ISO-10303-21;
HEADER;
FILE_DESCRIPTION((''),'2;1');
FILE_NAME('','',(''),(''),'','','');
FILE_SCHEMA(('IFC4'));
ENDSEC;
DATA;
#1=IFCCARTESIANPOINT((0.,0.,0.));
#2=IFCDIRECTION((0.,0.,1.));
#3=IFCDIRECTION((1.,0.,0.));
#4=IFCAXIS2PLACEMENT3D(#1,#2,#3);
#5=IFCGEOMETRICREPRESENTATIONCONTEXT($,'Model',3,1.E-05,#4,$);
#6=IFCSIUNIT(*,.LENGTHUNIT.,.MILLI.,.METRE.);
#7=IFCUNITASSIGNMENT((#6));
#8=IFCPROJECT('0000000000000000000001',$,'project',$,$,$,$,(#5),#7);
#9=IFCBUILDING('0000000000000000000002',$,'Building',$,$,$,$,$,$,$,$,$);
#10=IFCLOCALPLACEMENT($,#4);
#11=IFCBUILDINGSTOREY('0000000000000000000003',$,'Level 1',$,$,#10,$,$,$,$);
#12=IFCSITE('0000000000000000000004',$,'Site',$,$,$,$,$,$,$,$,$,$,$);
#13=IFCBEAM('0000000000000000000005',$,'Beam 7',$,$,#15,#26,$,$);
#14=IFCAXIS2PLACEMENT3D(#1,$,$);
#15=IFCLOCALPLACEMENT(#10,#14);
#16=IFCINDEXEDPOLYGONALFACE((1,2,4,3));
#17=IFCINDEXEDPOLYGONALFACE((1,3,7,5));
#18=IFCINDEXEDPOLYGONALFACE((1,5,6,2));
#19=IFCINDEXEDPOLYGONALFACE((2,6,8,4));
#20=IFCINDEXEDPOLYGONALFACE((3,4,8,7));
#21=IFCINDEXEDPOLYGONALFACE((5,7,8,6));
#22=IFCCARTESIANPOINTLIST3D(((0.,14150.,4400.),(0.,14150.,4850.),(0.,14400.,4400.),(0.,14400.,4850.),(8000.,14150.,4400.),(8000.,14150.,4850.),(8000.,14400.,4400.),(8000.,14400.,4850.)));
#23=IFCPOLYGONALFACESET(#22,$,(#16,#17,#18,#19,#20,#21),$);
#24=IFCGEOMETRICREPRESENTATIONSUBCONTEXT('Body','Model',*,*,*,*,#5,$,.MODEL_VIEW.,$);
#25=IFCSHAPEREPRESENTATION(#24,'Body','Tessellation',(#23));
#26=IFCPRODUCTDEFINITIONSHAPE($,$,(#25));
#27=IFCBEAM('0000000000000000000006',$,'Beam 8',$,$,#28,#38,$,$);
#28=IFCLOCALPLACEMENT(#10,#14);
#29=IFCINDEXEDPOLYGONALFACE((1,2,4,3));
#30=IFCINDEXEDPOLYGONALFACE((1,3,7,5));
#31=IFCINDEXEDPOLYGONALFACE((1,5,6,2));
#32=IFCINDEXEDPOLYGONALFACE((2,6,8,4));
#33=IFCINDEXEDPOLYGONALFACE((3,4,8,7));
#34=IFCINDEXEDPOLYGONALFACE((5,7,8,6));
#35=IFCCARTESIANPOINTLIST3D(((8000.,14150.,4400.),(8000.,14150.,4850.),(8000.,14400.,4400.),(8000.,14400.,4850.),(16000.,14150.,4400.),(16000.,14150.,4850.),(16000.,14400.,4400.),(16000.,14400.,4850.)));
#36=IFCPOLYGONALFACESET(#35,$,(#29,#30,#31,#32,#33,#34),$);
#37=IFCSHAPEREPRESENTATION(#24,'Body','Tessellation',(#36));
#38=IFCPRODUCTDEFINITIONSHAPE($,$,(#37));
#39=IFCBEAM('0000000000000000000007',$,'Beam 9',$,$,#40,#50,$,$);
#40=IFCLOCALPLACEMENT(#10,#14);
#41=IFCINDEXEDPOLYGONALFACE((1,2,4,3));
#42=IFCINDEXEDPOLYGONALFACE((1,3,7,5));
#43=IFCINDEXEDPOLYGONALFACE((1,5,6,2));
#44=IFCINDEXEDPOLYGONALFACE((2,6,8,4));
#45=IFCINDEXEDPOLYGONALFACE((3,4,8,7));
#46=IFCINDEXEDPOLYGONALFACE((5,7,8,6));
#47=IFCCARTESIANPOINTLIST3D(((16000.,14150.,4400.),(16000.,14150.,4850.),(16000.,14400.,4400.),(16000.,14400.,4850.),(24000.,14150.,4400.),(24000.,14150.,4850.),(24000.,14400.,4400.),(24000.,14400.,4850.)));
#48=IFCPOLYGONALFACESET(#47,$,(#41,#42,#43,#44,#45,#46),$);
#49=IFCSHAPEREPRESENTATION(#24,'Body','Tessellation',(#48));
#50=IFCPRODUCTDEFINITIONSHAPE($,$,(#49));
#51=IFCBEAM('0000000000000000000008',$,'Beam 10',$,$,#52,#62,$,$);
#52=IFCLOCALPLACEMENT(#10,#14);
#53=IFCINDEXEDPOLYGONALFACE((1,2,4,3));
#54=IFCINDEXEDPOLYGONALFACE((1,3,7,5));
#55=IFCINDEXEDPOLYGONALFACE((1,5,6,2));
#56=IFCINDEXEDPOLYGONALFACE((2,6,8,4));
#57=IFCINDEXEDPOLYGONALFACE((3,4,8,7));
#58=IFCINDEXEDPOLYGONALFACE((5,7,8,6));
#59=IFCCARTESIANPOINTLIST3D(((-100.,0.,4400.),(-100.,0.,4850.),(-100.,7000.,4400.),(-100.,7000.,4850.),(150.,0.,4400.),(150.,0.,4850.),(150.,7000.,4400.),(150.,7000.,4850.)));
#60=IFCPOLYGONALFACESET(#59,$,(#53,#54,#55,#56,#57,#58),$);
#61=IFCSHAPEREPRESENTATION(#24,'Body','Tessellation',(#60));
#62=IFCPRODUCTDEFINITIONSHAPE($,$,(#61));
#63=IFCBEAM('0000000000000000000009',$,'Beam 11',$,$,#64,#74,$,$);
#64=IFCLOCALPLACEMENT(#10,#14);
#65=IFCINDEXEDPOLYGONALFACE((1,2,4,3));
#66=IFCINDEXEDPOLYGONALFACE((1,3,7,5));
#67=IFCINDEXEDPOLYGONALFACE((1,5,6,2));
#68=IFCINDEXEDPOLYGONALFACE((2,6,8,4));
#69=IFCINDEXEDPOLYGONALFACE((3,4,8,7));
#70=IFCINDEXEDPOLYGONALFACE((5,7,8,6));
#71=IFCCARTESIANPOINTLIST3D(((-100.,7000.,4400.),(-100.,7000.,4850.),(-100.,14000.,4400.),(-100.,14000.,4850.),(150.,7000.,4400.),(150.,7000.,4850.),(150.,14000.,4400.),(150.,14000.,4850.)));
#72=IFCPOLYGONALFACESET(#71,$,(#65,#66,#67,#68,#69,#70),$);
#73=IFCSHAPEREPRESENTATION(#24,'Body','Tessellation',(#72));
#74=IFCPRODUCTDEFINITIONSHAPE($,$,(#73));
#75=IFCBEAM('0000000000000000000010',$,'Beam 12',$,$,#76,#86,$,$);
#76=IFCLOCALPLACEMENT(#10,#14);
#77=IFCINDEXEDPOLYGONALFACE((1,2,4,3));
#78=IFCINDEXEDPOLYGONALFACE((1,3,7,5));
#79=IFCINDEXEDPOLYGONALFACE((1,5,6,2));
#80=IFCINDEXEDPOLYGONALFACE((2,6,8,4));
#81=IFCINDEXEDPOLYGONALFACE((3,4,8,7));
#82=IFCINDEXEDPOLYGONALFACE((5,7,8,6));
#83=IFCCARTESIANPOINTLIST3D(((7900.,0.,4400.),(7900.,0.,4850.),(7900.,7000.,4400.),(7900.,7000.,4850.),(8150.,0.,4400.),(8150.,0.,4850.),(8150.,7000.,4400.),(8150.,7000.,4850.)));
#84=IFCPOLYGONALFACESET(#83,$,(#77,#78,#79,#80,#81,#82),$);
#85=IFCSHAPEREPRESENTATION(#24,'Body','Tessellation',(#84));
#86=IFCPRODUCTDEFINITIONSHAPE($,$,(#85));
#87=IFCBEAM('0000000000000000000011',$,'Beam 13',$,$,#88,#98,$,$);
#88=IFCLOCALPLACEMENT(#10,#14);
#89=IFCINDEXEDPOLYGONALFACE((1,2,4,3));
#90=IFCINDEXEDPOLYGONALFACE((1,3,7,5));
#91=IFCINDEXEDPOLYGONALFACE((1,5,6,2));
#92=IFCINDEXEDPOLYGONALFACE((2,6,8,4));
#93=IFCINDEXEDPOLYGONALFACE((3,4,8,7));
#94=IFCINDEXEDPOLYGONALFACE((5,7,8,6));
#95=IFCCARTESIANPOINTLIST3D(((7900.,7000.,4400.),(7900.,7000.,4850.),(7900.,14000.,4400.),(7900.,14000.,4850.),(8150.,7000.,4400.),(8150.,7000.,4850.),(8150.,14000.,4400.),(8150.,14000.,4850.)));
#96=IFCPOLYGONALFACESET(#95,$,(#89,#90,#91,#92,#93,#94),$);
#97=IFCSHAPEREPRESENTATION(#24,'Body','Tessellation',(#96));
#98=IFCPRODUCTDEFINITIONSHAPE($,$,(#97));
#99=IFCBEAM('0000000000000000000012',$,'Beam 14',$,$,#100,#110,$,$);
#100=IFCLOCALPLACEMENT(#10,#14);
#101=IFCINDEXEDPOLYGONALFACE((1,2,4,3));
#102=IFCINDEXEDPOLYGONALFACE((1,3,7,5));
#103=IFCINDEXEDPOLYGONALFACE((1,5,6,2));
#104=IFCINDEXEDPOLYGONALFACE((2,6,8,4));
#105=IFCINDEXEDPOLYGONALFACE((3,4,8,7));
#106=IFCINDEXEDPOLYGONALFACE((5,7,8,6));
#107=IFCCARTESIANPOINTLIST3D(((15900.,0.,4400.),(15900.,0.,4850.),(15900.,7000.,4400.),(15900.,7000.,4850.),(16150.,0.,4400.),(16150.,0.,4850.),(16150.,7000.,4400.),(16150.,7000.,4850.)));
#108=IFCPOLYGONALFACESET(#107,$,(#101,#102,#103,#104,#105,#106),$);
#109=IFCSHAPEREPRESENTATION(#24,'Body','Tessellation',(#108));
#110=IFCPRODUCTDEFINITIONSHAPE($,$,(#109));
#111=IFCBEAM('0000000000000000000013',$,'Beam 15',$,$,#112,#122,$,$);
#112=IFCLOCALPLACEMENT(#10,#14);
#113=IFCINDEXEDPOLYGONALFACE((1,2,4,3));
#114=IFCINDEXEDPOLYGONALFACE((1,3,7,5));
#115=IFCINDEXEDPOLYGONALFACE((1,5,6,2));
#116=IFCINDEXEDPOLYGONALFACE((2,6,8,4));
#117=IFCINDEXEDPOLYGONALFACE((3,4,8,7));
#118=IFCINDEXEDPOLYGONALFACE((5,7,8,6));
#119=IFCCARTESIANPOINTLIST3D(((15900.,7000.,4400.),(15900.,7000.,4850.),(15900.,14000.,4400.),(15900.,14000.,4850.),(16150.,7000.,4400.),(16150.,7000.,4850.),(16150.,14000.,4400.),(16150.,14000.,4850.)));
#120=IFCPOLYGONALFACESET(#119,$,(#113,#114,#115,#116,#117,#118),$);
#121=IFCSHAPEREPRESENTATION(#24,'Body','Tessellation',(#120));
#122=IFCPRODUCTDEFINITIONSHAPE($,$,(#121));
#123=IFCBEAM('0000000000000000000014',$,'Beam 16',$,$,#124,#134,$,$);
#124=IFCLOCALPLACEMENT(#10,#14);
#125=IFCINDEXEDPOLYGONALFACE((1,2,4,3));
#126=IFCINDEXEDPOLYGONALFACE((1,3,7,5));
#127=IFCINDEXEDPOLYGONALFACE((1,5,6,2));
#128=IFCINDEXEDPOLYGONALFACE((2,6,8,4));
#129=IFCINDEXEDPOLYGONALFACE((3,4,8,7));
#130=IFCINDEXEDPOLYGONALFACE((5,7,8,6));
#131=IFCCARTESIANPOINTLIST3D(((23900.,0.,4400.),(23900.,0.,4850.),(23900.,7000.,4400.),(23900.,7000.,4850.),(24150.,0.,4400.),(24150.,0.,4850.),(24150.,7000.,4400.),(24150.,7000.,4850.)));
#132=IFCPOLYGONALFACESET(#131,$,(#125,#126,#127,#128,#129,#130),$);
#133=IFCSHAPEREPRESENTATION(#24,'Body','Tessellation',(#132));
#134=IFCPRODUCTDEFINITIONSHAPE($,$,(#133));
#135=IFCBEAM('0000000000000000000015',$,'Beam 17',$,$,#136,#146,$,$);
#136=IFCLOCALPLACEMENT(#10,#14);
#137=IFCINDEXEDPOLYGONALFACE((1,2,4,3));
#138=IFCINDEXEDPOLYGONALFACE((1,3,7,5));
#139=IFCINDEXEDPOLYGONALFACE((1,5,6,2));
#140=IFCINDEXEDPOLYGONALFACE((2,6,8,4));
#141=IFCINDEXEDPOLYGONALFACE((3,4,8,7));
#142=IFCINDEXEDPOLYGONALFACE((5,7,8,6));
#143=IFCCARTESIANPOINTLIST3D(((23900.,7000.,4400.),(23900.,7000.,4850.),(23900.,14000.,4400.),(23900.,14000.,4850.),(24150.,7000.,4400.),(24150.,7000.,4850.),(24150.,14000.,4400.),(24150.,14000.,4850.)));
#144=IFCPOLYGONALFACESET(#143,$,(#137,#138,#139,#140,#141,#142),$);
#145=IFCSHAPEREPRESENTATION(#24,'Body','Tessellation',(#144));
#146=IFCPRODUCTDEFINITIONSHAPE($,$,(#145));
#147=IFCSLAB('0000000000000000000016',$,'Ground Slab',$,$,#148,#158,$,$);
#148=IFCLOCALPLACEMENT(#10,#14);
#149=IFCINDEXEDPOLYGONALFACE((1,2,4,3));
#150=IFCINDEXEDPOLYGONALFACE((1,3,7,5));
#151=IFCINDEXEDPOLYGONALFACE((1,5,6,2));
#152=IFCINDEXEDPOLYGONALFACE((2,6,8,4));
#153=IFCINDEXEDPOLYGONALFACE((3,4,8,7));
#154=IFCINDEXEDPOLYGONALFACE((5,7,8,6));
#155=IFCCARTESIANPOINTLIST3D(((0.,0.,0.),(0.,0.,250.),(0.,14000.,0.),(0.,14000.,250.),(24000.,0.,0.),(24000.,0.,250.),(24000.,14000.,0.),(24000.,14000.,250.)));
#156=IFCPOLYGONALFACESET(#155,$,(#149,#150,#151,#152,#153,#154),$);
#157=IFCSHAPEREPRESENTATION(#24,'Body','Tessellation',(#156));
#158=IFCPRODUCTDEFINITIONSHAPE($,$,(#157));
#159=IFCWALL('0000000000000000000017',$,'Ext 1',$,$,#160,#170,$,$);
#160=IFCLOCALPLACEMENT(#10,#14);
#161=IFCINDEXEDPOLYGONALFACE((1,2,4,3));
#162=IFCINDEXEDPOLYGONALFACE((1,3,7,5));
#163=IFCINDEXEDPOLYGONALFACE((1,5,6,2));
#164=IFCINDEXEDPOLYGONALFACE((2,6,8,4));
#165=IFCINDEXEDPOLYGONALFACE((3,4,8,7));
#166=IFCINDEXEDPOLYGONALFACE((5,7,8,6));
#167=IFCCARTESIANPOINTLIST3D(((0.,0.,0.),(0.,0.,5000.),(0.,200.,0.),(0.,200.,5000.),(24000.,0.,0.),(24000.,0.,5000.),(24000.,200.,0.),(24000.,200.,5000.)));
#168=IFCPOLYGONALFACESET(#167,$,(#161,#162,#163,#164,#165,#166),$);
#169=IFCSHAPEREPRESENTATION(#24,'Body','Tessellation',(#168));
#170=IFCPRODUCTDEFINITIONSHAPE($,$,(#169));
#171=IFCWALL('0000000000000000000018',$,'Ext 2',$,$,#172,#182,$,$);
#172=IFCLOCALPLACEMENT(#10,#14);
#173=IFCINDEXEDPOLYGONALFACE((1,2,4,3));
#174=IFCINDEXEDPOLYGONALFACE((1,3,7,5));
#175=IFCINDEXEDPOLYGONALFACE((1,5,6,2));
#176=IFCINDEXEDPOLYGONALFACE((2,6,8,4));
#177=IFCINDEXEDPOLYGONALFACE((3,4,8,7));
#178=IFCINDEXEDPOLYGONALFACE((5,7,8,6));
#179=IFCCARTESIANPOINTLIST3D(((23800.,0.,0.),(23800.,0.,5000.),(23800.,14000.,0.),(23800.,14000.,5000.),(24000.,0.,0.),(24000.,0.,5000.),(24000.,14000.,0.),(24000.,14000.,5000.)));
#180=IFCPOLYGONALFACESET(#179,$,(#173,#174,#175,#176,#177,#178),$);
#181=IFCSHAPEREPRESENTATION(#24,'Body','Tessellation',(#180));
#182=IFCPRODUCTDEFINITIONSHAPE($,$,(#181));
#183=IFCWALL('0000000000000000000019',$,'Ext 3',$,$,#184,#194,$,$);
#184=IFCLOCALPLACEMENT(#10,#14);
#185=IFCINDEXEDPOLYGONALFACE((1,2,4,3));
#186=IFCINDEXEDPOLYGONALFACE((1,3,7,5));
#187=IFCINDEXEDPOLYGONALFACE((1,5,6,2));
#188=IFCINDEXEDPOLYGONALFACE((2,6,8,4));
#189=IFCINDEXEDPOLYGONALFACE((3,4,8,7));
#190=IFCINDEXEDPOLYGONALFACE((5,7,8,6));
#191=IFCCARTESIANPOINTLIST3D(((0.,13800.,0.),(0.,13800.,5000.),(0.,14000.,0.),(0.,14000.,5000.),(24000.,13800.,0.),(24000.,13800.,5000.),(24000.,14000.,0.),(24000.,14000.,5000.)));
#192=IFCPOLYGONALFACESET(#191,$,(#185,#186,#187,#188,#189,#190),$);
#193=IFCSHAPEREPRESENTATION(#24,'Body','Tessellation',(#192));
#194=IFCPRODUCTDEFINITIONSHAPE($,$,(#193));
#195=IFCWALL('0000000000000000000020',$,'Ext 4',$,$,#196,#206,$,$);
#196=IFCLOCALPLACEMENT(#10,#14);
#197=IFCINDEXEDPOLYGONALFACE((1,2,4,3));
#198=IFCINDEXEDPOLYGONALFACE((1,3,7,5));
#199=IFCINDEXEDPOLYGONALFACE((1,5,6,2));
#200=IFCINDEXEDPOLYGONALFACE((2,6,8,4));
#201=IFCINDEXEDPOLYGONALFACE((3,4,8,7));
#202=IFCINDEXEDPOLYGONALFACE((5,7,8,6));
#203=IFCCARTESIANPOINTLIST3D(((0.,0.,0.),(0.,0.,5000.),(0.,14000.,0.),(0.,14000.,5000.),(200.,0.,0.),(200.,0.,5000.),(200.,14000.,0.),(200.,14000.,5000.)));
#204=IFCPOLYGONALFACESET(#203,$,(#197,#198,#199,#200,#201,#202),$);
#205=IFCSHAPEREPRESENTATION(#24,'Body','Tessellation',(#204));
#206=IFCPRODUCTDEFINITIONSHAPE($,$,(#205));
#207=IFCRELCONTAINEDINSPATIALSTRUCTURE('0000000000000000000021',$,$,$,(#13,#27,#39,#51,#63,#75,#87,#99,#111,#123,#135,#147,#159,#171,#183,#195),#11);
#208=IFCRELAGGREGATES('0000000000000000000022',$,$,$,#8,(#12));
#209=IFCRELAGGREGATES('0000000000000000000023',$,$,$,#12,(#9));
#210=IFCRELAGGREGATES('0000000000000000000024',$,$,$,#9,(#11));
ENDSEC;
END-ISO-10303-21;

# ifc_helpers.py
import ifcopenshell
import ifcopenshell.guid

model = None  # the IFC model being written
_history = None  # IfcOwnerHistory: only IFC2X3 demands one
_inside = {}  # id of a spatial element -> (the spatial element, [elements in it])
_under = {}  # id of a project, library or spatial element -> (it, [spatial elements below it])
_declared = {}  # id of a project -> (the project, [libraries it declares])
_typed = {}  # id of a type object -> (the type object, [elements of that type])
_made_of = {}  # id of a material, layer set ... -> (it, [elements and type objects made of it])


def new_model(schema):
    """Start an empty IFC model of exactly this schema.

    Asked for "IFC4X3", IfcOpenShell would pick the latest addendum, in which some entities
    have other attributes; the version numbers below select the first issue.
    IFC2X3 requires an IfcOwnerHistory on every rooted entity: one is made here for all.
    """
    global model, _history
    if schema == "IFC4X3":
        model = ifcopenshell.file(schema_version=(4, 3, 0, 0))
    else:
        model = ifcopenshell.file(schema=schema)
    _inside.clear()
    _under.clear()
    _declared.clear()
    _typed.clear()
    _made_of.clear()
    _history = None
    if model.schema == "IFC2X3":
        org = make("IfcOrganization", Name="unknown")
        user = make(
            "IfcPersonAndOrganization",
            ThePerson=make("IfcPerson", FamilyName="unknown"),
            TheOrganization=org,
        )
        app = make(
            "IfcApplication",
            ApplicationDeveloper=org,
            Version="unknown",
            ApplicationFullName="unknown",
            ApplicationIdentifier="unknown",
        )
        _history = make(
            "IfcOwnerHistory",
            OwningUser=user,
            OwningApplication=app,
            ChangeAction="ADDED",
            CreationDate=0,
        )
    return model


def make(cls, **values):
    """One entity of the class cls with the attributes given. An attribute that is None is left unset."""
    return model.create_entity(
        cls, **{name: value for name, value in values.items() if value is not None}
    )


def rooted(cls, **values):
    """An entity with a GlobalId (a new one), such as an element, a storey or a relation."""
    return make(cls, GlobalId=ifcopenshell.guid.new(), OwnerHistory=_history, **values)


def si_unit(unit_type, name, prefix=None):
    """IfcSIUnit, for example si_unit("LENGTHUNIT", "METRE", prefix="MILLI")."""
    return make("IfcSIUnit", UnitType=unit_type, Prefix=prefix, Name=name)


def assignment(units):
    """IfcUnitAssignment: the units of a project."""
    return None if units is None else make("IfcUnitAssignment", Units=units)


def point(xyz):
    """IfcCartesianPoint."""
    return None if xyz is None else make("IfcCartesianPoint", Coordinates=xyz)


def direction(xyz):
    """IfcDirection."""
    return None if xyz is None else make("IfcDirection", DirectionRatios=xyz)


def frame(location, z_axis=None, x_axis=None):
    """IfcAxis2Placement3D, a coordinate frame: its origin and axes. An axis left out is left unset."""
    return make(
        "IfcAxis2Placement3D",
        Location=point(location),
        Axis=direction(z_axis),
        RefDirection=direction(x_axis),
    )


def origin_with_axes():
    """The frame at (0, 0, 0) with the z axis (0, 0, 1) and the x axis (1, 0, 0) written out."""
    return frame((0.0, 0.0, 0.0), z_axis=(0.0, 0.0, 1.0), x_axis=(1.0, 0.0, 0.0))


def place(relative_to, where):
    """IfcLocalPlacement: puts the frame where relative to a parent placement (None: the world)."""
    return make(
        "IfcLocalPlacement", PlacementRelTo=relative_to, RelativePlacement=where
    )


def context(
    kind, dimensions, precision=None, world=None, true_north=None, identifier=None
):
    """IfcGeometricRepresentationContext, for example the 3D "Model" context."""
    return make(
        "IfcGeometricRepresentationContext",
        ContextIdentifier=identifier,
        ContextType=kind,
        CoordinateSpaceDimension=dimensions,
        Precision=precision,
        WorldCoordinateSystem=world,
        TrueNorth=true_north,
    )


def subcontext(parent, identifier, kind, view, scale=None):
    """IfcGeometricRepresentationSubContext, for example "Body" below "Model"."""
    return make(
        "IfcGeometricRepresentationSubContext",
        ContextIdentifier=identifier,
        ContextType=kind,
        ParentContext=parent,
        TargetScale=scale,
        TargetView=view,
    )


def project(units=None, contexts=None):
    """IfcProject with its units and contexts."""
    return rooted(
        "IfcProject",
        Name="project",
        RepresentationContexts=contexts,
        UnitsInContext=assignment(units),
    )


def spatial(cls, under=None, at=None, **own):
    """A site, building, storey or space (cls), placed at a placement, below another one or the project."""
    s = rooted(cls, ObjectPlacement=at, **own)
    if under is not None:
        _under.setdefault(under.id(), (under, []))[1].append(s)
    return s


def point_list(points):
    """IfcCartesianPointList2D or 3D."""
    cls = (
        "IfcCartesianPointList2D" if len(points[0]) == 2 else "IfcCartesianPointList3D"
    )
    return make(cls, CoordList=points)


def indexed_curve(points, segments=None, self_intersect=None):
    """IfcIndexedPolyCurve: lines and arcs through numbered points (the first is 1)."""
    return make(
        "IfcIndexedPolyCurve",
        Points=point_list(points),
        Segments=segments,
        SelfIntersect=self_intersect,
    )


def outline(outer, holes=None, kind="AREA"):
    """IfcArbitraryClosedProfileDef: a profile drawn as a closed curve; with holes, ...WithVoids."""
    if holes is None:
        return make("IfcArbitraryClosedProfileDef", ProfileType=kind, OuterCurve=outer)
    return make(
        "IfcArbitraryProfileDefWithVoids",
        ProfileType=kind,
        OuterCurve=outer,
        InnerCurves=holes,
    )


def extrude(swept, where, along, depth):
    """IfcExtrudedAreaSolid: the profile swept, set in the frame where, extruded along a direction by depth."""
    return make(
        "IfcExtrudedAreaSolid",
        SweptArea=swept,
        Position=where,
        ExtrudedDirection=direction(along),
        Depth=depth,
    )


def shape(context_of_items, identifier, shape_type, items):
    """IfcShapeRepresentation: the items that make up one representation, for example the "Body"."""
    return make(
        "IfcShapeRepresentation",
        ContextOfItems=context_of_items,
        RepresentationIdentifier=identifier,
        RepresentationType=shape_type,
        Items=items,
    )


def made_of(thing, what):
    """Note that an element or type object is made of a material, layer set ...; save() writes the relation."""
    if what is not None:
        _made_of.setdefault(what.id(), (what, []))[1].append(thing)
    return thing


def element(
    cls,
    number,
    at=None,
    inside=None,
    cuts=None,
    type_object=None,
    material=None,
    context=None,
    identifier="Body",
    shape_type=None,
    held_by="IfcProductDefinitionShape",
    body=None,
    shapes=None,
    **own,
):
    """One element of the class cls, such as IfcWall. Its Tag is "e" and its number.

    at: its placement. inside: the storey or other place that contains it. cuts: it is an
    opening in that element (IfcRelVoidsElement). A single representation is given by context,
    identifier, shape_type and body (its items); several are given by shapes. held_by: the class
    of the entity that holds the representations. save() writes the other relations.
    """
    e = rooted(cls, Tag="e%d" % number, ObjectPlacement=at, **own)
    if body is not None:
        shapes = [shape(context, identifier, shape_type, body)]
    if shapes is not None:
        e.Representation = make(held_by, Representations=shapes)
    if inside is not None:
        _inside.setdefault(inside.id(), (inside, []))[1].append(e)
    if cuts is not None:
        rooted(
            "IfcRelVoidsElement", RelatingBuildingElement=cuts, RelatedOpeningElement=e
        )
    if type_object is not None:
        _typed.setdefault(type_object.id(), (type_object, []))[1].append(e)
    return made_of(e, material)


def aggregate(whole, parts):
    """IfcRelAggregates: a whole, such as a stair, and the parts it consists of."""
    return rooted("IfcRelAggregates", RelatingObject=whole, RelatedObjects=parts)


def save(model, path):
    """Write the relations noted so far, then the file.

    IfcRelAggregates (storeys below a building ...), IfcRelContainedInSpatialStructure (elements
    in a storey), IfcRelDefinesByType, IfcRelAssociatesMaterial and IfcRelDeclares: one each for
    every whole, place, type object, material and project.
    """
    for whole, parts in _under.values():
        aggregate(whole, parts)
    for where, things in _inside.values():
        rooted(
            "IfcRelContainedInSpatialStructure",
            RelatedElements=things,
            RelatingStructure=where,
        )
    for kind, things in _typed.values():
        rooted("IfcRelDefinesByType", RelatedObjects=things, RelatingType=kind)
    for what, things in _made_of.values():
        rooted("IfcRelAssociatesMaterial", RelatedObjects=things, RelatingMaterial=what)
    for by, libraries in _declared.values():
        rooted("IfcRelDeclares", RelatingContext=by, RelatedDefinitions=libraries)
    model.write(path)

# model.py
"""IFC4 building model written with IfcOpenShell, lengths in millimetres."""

from ifc_helpers import new_model, si_unit, frame, origin_with_axes, place, context, subcontext, project, spatial, indexed_curve, outline, extrude, element, save


model = new_model("IFC4")

# Units and contexts
model_context = context("Model", 3, precision=1e-05, world=origin_with_axes())
body_context = subcontext(model_context, "Body", "Model", "MODEL_VIEW")
ifc_project = project(units=[si_unit("LENGTHUNIT", "METRE", prefix="MILLI")], contexts=[model_context])

# Site, building, storey
site = spatial("IfcSite", under=ifc_project, Name="Site")
building = spatial("IfcBuilding", under=site, Name="Building")
storey_placement = place(None, origin_with_axes())
storey = spatial("IfcBuildingStorey", under=building, at=storey_placement, Name="Level 1")

# Beams
for number, where, z_axis, x_axis, name in (
    (1, (0.0, 14150.0, 4400.0), (0.0, 0.0, 1.0), (1.0, 0.0, 0.0), "Beam 7"),
    (2, (8000.0, 14150.0, 4400.0), (0.0, 0.0, 1.0), (1.0, 0.0, 0.0), "Beam 8"),
    (3, (16000.0, 14150.0, 4400.0), (0.0, 0.0, 1.0), (1.0, 0.0, 0.0), "Beam 9"),
):
    element("IfcBeam", number, at=place(storey_placement, frame(where, z_axis=z_axis, x_axis=x_axis)), inside=storey, Name=name, context=body_context, shape_type="SweptSolid", body=[
        extrude(outline(indexed_curve([(0.0, 0.0), (0.0, 250.0), (8000.0, 250.0), (8000.0, 0.0), (0.0, 0.0)], self_intersect=False)), origin_with_axes(), (0.0, 0.0, 1.0), 450.0),
    ])
for number, where, z_axis, x_axis, name in (
    (4, (150.0, 0.0, 4400.0), (0.0, 0.0, 1.0), (0.0, 1.0, 0.0), "Beam 10"),
    (5, (150.0, 7000.0, 4400.0), (0.0, 0.0, 1.0), (0.0, 1.0, 0.0), "Beam 11"),
    (6, (8150.0, 0.0, 4400.0), (0.0, 0.0, 1.0), (0.0, 1.0, 0.0), "Beam 12"),
    (7, (8150.0, 7000.0, 4400.0), (0.0, 0.0, 1.0), (0.0, 1.0, 0.0), "Beam 13"),
    (8, (16150.0, 0.0, 4400.0), (0.0, 0.0, 1.0), (0.0, 1.0, 0.0), "Beam 14"),
    (9, (16150.0, 7000.0, 4400.0), (0.0, 0.0, 1.0), (0.0, 1.0, 0.0), "Beam 15"),
    (10, (24150.0, 0.0, 4400.0), (0.0, 0.0, 1.0), (0.0, 1.0, 0.0), "Beam 16"),
    (11, (24150.0, 7000.0, 4400.0), (0.0, 0.0, 1.0), (0.0, 1.0, 0.0), "Beam 17"),
):
    element("IfcBeam", number, at=place(storey_placement, frame(where, z_axis=z_axis, x_axis=x_axis)), inside=storey, Name=name, context=body_context, shape_type="SweptSolid", body=[
        extrude(outline(indexed_curve([(0.0, 0.0), (0.0, 250.0), (7000.0, 250.0), (7000.0, 0.0), (0.0, 0.0)], self_intersect=False)), origin_with_axes(), (0.0, 0.0, 1.0), 450.0),
    ])

# Slab
slab_placement = place(storey_placement, origin_with_axes())
element("IfcSlab", 12, at=slab_placement, inside=storey, Name="Ground Slab", context=body_context, shape_type="SweptSolid", body=[
    extrude(outline(indexed_curve([(0.0, 0.0), (24000.0, 0.0), (24000.0, 14000.0), (0.0, 14000.0), (0.0, 0.0)])), None, (0.0, 0.0, 1.0), 250.0),
])

# Walls
wall_1_placement = place(storey_placement, origin_with_axes())
element("IfcWall", 13, at=wall_1_placement, inside=storey, Name="Ext 1", context=body_context, shape_type="SweptSolid", body=[
    extrude(outline(indexed_curve([(0.0, 0.0), (0.0, 200.0), (24000.0, 200.0), (24000.0, 0.0), (0.0, 0.0)], self_intersect=False)), origin_with_axes(), (0.0, 0.0, 1.0), 5000.0),
])
wall_2_placement = place(storey_placement, frame((24000.0, 0.0, 0.0), z_axis=(0.0, 0.0, 1.0), x_axis=(0.0, 1.0, 0.0)))
element("IfcWall", 14, at=wall_2_placement, inside=storey, Name="Ext 2", context=body_context, shape_type="SweptSolid", body=[
    extrude(outline(indexed_curve([(0.0, 0.0), (0.0, 200.0), (14000.0, 200.0), (14000.0, 0.0), (0.0, 0.0)], self_intersect=False)), origin_with_axes(), (0.0, 0.0, 1.0), 5000.0),
])
wall_3_placement = place(storey_placement, frame((24000.0, 14000.0, 0.0), z_axis=(0.0, 0.0, 1.0), x_axis=(-1.0, 0.0, 0.0)))
element("IfcWall", 15, at=wall_3_placement, inside=storey, Name="Ext 3", context=body_context, shape_type="SweptSolid", body=[
    extrude(outline(indexed_curve([(0.0, 0.0), (0.0, 200.0), (24000.0, 200.0), (24000.0, 0.0), (0.0, 0.0)], self_intersect=False)), origin_with_axes(), (0.0, 0.0, 1.0), 5000.0),
])
wall_4_placement = place(storey_placement, frame((0.0, 14000.0, 0.0), z_axis=(0.0, 0.0, 1.0), x_axis=(0.0, -1.0, 0.0)))
element("IfcWall", 16, at=wall_4_placement, inside=storey, Name="Ext 4", context=body_context, shape_type="SweptSolid", body=[
    extrude(outline(indexed_curve([(0.0, 0.0), (0.0, 200.0), (14000.0, 200.0), (14000.0, 0.0), (0.0, 0.0)], self_intersect=False)), origin_with_axes(), (0.0, 0.0, 1.0), 5000.0),
])

save(model, "model.ifc")
